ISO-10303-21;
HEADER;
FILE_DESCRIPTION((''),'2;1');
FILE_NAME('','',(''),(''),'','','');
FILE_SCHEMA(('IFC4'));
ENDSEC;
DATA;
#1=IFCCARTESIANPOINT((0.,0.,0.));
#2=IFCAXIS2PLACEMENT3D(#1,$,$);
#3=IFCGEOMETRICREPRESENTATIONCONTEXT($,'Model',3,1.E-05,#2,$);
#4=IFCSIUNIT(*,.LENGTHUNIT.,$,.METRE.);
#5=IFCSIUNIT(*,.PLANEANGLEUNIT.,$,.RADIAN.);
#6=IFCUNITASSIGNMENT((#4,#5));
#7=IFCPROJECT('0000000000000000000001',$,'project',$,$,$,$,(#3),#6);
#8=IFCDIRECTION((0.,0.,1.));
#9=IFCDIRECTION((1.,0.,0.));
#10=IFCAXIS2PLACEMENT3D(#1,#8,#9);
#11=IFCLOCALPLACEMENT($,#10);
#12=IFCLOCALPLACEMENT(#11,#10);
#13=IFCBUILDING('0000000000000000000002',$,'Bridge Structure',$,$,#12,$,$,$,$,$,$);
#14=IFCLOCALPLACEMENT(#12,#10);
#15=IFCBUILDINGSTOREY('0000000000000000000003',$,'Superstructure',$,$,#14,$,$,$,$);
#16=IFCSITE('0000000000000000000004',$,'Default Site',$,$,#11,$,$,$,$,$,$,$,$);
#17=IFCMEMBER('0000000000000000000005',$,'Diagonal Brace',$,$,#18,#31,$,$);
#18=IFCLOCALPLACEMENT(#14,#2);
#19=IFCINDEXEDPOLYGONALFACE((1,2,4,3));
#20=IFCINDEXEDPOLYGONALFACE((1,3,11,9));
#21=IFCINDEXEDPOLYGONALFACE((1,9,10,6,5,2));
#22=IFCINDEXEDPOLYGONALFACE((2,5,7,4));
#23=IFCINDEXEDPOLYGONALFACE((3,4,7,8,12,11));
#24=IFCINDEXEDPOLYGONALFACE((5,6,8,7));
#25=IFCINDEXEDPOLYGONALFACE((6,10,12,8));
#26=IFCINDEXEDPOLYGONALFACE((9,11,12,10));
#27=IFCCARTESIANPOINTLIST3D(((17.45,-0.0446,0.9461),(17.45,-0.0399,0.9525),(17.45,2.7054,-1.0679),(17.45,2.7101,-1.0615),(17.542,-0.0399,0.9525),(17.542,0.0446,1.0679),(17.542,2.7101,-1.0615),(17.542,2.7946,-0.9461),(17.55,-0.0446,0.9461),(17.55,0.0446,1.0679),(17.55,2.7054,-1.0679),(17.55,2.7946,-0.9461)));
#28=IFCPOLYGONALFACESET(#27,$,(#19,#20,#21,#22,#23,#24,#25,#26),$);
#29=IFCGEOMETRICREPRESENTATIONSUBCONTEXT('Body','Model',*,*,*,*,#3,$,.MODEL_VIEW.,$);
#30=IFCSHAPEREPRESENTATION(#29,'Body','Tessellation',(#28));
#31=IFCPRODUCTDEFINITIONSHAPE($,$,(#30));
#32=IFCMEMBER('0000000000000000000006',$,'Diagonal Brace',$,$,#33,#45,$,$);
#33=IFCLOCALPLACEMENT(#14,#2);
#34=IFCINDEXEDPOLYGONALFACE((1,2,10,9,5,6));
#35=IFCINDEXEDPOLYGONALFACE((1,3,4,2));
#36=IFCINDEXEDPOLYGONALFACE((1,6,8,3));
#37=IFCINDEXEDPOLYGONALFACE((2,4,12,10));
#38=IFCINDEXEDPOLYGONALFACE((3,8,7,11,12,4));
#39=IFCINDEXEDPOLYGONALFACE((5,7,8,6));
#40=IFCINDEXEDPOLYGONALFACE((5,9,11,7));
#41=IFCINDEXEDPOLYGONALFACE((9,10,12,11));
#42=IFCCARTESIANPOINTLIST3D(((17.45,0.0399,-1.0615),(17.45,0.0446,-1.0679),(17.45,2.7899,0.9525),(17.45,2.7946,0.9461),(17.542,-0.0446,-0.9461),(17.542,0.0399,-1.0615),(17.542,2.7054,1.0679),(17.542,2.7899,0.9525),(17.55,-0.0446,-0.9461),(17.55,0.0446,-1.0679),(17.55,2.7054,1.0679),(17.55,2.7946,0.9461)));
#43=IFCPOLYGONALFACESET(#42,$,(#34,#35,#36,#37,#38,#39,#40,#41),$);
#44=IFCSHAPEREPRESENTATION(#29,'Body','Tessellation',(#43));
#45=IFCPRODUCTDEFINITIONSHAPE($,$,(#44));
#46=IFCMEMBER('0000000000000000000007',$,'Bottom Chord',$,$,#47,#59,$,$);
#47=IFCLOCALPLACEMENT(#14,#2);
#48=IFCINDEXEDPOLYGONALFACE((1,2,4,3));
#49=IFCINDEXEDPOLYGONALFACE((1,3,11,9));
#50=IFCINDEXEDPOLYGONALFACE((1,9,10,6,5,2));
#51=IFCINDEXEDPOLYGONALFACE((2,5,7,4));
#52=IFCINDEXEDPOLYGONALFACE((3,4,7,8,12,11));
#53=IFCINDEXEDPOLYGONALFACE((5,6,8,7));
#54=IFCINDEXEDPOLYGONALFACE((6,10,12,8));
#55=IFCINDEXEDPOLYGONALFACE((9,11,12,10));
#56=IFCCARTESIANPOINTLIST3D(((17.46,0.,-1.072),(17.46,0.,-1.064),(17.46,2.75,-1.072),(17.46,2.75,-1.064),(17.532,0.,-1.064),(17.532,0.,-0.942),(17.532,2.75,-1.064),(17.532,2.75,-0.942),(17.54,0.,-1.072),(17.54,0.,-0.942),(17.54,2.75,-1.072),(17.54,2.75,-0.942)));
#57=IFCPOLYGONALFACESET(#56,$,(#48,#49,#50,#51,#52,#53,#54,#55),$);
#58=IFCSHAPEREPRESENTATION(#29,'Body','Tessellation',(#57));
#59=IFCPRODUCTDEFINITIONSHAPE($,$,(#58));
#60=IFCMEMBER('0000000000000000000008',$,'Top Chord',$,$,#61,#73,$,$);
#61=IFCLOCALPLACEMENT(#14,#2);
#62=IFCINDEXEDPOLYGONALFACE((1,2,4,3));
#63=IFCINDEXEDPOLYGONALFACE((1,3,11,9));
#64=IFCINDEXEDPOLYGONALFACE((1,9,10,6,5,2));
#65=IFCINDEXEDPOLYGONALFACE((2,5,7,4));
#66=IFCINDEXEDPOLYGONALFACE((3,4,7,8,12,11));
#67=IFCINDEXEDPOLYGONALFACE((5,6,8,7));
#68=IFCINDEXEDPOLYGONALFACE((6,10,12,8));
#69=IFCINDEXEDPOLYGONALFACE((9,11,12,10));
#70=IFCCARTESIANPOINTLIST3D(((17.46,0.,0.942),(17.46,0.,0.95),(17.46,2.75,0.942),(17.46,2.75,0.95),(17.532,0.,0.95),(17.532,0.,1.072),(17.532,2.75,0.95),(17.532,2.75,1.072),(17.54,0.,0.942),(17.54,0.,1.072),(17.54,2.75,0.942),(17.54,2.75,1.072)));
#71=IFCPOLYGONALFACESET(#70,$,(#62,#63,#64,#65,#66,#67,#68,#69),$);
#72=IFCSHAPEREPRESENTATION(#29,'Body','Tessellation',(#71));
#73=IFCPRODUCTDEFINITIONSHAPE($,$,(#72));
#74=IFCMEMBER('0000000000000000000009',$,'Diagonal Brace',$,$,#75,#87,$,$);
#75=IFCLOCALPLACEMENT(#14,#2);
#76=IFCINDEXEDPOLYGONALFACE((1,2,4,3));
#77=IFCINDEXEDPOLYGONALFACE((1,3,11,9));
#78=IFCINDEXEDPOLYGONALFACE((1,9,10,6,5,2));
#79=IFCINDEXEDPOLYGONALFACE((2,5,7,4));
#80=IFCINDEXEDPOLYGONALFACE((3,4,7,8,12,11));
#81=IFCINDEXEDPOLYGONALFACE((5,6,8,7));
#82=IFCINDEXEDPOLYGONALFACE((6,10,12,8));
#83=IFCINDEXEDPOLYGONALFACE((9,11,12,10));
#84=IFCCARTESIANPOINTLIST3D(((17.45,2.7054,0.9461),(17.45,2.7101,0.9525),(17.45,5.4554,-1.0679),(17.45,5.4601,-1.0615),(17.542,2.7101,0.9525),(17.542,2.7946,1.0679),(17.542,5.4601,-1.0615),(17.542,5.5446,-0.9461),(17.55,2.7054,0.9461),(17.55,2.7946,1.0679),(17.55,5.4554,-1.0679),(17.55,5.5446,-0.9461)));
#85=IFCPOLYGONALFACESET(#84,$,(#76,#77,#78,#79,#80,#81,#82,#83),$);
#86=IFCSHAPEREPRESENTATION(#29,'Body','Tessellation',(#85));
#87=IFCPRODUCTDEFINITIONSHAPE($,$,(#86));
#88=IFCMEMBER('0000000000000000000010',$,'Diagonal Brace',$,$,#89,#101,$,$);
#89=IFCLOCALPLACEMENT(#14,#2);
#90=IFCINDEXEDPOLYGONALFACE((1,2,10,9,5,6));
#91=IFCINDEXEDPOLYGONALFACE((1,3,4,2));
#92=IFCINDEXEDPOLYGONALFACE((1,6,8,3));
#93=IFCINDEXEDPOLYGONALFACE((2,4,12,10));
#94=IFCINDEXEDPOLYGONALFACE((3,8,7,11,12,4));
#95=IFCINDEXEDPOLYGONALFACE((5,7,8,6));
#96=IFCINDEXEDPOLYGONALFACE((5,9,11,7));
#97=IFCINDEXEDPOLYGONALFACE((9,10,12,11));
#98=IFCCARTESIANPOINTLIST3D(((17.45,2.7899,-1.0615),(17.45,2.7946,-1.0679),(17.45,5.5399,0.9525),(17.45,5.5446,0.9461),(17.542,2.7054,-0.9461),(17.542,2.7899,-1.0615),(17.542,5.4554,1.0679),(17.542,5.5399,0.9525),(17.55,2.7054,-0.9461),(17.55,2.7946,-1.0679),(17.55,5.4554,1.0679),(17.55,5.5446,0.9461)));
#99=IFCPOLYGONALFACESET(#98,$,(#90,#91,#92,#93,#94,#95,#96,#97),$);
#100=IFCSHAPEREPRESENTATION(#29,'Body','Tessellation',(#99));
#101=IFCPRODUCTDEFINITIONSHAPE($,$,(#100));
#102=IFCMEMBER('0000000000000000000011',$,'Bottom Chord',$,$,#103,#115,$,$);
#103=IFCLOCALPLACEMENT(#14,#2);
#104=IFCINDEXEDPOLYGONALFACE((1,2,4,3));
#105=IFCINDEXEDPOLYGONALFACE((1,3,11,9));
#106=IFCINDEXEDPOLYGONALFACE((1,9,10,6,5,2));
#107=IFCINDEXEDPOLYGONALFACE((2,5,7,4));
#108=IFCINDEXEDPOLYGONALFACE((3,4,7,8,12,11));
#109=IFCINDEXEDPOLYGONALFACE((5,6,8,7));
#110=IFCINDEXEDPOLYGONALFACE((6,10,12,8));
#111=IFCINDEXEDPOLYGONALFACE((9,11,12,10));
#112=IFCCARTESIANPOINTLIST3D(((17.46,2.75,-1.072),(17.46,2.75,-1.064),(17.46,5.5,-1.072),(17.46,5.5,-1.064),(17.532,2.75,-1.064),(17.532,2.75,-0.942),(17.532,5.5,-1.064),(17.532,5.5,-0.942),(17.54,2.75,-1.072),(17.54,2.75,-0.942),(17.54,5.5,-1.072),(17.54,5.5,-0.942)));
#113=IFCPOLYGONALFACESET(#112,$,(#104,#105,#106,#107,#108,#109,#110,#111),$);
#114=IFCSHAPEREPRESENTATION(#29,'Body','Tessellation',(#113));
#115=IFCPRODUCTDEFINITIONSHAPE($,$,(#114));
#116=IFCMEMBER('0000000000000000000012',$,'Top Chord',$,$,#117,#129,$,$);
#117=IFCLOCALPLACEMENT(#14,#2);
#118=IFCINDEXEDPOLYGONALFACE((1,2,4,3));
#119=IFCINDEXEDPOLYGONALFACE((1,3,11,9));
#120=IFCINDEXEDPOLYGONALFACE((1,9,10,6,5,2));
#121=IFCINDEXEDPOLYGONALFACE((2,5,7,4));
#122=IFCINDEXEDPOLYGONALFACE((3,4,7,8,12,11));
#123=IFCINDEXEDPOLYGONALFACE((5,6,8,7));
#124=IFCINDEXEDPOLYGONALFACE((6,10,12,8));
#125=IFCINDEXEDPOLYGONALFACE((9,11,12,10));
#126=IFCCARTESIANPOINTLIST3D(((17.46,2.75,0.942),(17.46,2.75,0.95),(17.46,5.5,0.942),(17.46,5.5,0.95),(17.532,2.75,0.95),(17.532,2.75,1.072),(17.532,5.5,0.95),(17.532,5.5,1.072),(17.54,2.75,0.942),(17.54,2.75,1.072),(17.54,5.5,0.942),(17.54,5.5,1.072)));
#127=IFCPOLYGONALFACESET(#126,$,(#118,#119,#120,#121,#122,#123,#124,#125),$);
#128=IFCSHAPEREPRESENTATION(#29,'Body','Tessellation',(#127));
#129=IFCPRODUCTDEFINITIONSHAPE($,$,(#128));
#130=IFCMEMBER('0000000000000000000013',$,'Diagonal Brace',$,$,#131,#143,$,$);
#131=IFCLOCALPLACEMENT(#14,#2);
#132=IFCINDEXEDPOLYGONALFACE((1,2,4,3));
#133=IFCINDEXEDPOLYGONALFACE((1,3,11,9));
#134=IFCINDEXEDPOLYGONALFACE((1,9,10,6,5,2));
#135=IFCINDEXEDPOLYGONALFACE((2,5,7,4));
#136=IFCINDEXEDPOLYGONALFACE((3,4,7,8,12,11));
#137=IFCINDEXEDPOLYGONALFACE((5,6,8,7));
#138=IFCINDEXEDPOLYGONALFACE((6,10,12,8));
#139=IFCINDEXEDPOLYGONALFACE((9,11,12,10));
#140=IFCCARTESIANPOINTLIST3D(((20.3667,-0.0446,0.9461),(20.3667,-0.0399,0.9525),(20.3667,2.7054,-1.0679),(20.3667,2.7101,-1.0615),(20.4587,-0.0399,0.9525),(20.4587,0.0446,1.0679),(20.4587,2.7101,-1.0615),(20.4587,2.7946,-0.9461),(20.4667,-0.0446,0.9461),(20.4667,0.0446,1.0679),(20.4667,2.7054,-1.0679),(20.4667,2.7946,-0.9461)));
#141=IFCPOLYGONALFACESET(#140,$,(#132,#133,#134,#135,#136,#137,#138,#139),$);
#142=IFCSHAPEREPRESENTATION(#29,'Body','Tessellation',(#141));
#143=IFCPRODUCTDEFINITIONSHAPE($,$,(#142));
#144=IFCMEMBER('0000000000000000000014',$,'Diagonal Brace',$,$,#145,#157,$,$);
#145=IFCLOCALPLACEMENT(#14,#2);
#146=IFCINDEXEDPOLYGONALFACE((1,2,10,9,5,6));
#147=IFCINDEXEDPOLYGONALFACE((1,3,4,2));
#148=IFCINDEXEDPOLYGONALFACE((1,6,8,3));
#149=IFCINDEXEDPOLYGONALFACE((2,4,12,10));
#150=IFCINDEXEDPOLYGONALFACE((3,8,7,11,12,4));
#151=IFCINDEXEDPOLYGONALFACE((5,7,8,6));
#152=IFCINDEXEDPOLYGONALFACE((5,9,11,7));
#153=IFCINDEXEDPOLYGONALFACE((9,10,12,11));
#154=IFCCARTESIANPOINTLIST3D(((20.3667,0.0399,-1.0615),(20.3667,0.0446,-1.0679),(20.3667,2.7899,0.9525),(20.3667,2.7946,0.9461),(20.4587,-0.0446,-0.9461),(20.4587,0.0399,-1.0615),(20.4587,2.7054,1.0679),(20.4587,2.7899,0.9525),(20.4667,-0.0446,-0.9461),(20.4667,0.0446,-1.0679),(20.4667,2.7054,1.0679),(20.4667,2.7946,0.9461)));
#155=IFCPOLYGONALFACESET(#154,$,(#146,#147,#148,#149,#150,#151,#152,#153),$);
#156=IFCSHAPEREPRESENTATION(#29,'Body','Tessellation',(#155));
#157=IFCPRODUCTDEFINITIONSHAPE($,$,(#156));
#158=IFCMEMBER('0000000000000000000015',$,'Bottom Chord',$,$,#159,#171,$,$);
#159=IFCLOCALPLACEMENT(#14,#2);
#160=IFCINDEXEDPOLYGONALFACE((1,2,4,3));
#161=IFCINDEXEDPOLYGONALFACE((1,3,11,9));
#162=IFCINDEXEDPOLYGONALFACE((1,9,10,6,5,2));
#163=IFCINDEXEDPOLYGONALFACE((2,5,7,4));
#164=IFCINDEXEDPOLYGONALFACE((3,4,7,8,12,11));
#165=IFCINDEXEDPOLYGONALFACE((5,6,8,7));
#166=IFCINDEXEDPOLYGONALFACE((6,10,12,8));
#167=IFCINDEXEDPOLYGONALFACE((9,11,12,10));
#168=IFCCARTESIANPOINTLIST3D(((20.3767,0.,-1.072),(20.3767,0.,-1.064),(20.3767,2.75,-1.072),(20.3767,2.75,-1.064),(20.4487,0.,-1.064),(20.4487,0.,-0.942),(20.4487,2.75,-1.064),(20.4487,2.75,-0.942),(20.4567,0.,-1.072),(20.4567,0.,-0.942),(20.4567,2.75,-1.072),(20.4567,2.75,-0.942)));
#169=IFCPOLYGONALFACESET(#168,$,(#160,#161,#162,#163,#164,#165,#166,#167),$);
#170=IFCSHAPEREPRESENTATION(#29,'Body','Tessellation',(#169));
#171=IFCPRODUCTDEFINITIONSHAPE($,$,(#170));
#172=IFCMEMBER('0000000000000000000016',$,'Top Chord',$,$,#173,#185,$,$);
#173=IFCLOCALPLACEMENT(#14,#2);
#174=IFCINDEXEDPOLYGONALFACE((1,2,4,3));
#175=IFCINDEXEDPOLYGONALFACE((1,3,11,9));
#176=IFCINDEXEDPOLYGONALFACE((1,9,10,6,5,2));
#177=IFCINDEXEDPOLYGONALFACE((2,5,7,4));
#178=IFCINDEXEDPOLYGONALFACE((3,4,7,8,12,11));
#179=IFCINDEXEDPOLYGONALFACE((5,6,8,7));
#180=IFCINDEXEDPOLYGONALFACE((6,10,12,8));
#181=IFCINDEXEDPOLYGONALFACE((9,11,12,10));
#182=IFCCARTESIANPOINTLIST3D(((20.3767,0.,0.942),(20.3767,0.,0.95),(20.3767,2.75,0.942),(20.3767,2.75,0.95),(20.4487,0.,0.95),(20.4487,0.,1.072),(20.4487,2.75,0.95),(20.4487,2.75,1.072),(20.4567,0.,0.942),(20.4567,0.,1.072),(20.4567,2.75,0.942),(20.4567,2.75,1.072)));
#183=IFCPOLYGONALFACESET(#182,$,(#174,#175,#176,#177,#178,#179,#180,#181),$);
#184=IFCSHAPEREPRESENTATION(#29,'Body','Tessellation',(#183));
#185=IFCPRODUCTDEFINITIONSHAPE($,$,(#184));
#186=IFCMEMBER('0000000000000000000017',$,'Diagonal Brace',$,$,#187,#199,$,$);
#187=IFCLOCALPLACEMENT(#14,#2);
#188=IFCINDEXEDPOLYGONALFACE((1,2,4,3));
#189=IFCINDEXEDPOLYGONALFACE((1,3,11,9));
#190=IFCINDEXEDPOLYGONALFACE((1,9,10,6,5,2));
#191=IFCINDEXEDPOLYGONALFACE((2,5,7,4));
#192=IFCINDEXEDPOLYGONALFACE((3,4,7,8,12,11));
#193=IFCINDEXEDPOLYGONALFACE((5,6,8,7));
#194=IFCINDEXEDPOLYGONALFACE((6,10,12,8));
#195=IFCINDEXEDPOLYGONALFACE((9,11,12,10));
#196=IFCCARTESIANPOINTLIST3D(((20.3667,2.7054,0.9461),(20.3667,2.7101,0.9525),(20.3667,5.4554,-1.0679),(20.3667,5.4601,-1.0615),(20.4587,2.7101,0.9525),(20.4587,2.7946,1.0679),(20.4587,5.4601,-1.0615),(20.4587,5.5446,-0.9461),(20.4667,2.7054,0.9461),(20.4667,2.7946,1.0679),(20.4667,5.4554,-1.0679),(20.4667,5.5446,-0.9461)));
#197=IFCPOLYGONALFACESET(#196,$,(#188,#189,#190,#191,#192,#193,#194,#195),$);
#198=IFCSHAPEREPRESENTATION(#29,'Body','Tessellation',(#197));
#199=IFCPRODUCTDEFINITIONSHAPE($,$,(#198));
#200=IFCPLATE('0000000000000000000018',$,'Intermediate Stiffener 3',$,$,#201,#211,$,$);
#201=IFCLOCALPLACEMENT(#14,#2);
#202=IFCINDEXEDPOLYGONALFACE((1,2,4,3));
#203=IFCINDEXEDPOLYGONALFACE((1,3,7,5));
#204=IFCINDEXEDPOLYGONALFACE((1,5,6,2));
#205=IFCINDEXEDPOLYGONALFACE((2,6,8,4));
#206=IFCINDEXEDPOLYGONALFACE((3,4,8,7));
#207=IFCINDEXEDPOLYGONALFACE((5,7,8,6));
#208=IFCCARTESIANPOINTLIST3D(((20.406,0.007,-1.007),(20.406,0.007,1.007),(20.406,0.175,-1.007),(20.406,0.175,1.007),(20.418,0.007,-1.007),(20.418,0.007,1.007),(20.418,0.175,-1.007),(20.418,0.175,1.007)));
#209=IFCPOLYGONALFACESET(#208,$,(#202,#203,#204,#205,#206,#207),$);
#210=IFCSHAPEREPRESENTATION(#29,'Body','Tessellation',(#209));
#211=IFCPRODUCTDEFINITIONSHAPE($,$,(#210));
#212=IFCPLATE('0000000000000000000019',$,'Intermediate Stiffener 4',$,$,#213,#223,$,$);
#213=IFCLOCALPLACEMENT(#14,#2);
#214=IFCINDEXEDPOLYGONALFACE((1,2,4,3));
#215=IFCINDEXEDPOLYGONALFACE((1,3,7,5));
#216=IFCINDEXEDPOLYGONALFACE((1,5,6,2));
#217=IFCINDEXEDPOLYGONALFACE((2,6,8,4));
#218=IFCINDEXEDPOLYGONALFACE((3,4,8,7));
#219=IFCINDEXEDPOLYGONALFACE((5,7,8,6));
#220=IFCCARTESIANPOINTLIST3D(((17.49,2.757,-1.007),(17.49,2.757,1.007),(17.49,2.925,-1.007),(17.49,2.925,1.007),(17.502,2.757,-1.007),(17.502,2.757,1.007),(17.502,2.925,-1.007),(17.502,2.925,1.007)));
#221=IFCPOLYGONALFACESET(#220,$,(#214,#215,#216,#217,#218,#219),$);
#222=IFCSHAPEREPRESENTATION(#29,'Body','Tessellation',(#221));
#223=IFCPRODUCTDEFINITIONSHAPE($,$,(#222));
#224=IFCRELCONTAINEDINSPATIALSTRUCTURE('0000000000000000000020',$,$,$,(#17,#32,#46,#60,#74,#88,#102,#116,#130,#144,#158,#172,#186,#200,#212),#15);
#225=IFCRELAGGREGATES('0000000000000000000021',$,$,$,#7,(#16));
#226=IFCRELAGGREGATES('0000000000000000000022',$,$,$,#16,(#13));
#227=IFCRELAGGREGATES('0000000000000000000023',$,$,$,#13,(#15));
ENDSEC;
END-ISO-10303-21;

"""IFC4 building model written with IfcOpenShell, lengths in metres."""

from ifc_helpers import new_model, si_unit, frame, origin, origin_with_axes, origin_2d_with_axis, place, context, subcontext, project, spatial, rectangle, l_section, extrude, element, save


model = new_model("IFC4")

# Units and contexts
model_context = context("Model", 3, precision=1e-05, world=origin())
body_context = subcontext(model_context, "Body", "Model", "MODEL_VIEW")
ifc_project = project(units=[si_unit("LENGTHUNIT", "METRE"), si_unit("PLANEANGLEUNIT", "RADIAN")], contexts=[model_context])

# Site, building, storey
site_placement = place(None, origin_with_axes())
site = spatial("IfcSite", under=ifc_project, at=site_placement, Name="Default Site")
building_placement = place(site_placement, origin_with_axes())
building = spatial("IfcBuilding", under=site, at=building_placement, Name="Bridge Structure")
storey_placement = place(building_placement, origin_with_axes())
storey = spatial("IfcBuildingStorey", under=building, at=storey_placement, Name="Superstructure")

# Members
for number, where, z_axis, x_axis, name in (
    (1, (17.5, 0.0, 1.007), (0.0, 0.806778, -0.590855), (-1.0, 0.0, 0.0), "Diagonal Brace"),
    (2, (17.5, 0.0, -1.007), (0.0, 0.806778, 0.590855), (-1.0, 0.0, 0.0), "Diagonal Brace"),
):
    element("IfcMember", number, at=place(storey_placement, frame(where, z_axis=z_axis, x_axis=x_axis)), inside=storey, Name=name, context=body_context, shape_type="SweptSolid", body=[
        extrude(l_section(Depth=0.151, Width=0.1, Thickness=0.008, at=origin_2d_with_axis()), origin_with_axes(), (0.0, 0.0, 1.0), 3.4086),
    ])
for number, where, z_axis, x_axis, name in (
    (3, (17.5, 0.0, -1.007), (0.0, 1.0, 0.0), (-1.0, 0.0, 0.0), "Bottom Chord"),
    (4, (17.5, 0.0, 1.007), (0.0, 1.0, 0.0), (-1.0, 0.0, 0.0), "Top Chord"),
):
    element("IfcMember", number, at=place(storey_placement, frame(where, z_axis=z_axis, x_axis=x_axis)), inside=storey, Name=name, context=body_context, shape_type="SweptSolid", body=[
        extrude(l_section(Depth=0.13, Width=0.08, Thickness=0.008, at=origin_2d_with_axis()), origin_with_axes(), (0.0, 0.0, 1.0), 2.75),
    ])
for number, where, z_axis, x_axis, name in (
    (5, (17.5, 2.75, 1.007), (0.0, 0.806778, -0.590855), (-1.0, 0.0, 0.0), "Diagonal Brace"),
    (6, (17.5, 2.75, -1.007), (0.0, 0.806778, 0.590855), (-1.0, 0.0, 0.0), "Diagonal Brace"),
):
    element("IfcMember", number, at=place(storey_placement, frame(where, z_axis=z_axis, x_axis=x_axis)), inside=storey, Name=name, context=body_context, shape_type="SweptSolid", body=[
        extrude(l_section(Depth=0.151, Width=0.1, Thickness=0.008, at=origin_2d_with_axis()), origin_with_axes(), (0.0, 0.0, 1.0), 3.4086),
    ])
for number, where, z_axis, x_axis, name in (
    (7, (17.5, 2.75, -1.007), (0.0, 1.0, 0.0), (-1.0, 0.0, 0.0), "Bottom Chord"),
    (8, (17.5, 2.75, 1.007), (0.0, 1.0, 0.0), (-1.0, 0.0, 0.0), "Top Chord"),
):
    element("IfcMember", number, at=place(storey_placement, frame(where, z_axis=z_axis, x_axis=x_axis)), inside=storey, Name=name, context=body_context, shape_type="SweptSolid", body=[
        extrude(l_section(Depth=0.13, Width=0.08, Thickness=0.008, at=origin_2d_with_axis()), origin_with_axes(), (0.0, 0.0, 1.0), 2.75),
    ])
for number, where, z_axis, x_axis, name in (
    (9, (20.4167, 0.0, 1.007), (0.0, 0.806778, -0.590855), (-1.0, 0.0, 0.0), "Diagonal Brace"),
    (10, (20.4167, 0.0, -1.007), (0.0, 0.806778, 0.590855), (-1.0, 0.0, 0.0), "Diagonal Brace"),
):
    element("IfcMember", number, at=place(storey_placement, frame(where, z_axis=z_axis, x_axis=x_axis)), inside=storey, Name=name, context=body_context, shape_type="SweptSolid", body=[
        extrude(l_section(Depth=0.151, Width=0.1, Thickness=0.008, at=origin_2d_with_axis()), origin_with_axes(), (0.0, 0.0, 1.0), 3.4086),
    ])
for number, where, z_axis, x_axis, name in (
    (11, (20.4167, 0.0, -1.007), (0.0, 1.0, 0.0), (-1.0, 0.0, 0.0), "Bottom Chord"),
    (12, (20.4167, 0.0, 1.007), (0.0, 1.0, 0.0), (-1.0, 0.0, 0.0), "Top Chord"),
):
    element("IfcMember", number, at=place(storey_placement, frame(where, z_axis=z_axis, x_axis=x_axis)), inside=storey, Name=name, context=body_context, shape_type="SweptSolid", body=[
        extrude(l_section(Depth=0.13, Width=0.08, Thickness=0.008, at=origin_2d_with_axis()), origin_with_axes(), (0.0, 0.0, 1.0), 2.75),
    ])
member_placement = place(storey_placement, frame((20.4167, 2.75, 1.007), z_axis=(0.0, 0.806778, -0.590855), x_axis=(-1.0, 0.0, 0.0)))
element("IfcMember", 13, at=member_placement, inside=storey, Name="Diagonal Brace", context=body_context, shape_type="SweptSolid", body=[
    extrude(l_section(Depth=0.151, Width=0.1, Thickness=0.008, at=origin_2d_with_axis()), origin_with_axes(), (0.0, 0.0, 1.0), 3.4086),
])

# Plates
for number, where, z_axis, x_axis, name in (
    (14, (20.412, 0.091, -1.007), (0.0, 0.0, 1.0), (1.0, 0.0, 0.0), "Intermediate Stiffener 3"),
    (15, (17.496, 2.841, -1.007), (0.0, 0.0, 1.0), (1.0, 0.0, 0.0), "Intermediate Stiffener 4"),
):
    element("IfcPlate", number, at=place(storey_placement, frame(where, z_axis=z_axis, x_axis=x_axis)), inside=storey, Name=name, context=body_context, shape_type="SweptSolid", body=[
        extrude(rectangle(XDim=0.012, YDim=0.168, at=origin_2d_with_axis()), origin_with_axes(), (0.0, 0.0, 1.0), 2.014),
    ])

save(model, "model.ifc")
